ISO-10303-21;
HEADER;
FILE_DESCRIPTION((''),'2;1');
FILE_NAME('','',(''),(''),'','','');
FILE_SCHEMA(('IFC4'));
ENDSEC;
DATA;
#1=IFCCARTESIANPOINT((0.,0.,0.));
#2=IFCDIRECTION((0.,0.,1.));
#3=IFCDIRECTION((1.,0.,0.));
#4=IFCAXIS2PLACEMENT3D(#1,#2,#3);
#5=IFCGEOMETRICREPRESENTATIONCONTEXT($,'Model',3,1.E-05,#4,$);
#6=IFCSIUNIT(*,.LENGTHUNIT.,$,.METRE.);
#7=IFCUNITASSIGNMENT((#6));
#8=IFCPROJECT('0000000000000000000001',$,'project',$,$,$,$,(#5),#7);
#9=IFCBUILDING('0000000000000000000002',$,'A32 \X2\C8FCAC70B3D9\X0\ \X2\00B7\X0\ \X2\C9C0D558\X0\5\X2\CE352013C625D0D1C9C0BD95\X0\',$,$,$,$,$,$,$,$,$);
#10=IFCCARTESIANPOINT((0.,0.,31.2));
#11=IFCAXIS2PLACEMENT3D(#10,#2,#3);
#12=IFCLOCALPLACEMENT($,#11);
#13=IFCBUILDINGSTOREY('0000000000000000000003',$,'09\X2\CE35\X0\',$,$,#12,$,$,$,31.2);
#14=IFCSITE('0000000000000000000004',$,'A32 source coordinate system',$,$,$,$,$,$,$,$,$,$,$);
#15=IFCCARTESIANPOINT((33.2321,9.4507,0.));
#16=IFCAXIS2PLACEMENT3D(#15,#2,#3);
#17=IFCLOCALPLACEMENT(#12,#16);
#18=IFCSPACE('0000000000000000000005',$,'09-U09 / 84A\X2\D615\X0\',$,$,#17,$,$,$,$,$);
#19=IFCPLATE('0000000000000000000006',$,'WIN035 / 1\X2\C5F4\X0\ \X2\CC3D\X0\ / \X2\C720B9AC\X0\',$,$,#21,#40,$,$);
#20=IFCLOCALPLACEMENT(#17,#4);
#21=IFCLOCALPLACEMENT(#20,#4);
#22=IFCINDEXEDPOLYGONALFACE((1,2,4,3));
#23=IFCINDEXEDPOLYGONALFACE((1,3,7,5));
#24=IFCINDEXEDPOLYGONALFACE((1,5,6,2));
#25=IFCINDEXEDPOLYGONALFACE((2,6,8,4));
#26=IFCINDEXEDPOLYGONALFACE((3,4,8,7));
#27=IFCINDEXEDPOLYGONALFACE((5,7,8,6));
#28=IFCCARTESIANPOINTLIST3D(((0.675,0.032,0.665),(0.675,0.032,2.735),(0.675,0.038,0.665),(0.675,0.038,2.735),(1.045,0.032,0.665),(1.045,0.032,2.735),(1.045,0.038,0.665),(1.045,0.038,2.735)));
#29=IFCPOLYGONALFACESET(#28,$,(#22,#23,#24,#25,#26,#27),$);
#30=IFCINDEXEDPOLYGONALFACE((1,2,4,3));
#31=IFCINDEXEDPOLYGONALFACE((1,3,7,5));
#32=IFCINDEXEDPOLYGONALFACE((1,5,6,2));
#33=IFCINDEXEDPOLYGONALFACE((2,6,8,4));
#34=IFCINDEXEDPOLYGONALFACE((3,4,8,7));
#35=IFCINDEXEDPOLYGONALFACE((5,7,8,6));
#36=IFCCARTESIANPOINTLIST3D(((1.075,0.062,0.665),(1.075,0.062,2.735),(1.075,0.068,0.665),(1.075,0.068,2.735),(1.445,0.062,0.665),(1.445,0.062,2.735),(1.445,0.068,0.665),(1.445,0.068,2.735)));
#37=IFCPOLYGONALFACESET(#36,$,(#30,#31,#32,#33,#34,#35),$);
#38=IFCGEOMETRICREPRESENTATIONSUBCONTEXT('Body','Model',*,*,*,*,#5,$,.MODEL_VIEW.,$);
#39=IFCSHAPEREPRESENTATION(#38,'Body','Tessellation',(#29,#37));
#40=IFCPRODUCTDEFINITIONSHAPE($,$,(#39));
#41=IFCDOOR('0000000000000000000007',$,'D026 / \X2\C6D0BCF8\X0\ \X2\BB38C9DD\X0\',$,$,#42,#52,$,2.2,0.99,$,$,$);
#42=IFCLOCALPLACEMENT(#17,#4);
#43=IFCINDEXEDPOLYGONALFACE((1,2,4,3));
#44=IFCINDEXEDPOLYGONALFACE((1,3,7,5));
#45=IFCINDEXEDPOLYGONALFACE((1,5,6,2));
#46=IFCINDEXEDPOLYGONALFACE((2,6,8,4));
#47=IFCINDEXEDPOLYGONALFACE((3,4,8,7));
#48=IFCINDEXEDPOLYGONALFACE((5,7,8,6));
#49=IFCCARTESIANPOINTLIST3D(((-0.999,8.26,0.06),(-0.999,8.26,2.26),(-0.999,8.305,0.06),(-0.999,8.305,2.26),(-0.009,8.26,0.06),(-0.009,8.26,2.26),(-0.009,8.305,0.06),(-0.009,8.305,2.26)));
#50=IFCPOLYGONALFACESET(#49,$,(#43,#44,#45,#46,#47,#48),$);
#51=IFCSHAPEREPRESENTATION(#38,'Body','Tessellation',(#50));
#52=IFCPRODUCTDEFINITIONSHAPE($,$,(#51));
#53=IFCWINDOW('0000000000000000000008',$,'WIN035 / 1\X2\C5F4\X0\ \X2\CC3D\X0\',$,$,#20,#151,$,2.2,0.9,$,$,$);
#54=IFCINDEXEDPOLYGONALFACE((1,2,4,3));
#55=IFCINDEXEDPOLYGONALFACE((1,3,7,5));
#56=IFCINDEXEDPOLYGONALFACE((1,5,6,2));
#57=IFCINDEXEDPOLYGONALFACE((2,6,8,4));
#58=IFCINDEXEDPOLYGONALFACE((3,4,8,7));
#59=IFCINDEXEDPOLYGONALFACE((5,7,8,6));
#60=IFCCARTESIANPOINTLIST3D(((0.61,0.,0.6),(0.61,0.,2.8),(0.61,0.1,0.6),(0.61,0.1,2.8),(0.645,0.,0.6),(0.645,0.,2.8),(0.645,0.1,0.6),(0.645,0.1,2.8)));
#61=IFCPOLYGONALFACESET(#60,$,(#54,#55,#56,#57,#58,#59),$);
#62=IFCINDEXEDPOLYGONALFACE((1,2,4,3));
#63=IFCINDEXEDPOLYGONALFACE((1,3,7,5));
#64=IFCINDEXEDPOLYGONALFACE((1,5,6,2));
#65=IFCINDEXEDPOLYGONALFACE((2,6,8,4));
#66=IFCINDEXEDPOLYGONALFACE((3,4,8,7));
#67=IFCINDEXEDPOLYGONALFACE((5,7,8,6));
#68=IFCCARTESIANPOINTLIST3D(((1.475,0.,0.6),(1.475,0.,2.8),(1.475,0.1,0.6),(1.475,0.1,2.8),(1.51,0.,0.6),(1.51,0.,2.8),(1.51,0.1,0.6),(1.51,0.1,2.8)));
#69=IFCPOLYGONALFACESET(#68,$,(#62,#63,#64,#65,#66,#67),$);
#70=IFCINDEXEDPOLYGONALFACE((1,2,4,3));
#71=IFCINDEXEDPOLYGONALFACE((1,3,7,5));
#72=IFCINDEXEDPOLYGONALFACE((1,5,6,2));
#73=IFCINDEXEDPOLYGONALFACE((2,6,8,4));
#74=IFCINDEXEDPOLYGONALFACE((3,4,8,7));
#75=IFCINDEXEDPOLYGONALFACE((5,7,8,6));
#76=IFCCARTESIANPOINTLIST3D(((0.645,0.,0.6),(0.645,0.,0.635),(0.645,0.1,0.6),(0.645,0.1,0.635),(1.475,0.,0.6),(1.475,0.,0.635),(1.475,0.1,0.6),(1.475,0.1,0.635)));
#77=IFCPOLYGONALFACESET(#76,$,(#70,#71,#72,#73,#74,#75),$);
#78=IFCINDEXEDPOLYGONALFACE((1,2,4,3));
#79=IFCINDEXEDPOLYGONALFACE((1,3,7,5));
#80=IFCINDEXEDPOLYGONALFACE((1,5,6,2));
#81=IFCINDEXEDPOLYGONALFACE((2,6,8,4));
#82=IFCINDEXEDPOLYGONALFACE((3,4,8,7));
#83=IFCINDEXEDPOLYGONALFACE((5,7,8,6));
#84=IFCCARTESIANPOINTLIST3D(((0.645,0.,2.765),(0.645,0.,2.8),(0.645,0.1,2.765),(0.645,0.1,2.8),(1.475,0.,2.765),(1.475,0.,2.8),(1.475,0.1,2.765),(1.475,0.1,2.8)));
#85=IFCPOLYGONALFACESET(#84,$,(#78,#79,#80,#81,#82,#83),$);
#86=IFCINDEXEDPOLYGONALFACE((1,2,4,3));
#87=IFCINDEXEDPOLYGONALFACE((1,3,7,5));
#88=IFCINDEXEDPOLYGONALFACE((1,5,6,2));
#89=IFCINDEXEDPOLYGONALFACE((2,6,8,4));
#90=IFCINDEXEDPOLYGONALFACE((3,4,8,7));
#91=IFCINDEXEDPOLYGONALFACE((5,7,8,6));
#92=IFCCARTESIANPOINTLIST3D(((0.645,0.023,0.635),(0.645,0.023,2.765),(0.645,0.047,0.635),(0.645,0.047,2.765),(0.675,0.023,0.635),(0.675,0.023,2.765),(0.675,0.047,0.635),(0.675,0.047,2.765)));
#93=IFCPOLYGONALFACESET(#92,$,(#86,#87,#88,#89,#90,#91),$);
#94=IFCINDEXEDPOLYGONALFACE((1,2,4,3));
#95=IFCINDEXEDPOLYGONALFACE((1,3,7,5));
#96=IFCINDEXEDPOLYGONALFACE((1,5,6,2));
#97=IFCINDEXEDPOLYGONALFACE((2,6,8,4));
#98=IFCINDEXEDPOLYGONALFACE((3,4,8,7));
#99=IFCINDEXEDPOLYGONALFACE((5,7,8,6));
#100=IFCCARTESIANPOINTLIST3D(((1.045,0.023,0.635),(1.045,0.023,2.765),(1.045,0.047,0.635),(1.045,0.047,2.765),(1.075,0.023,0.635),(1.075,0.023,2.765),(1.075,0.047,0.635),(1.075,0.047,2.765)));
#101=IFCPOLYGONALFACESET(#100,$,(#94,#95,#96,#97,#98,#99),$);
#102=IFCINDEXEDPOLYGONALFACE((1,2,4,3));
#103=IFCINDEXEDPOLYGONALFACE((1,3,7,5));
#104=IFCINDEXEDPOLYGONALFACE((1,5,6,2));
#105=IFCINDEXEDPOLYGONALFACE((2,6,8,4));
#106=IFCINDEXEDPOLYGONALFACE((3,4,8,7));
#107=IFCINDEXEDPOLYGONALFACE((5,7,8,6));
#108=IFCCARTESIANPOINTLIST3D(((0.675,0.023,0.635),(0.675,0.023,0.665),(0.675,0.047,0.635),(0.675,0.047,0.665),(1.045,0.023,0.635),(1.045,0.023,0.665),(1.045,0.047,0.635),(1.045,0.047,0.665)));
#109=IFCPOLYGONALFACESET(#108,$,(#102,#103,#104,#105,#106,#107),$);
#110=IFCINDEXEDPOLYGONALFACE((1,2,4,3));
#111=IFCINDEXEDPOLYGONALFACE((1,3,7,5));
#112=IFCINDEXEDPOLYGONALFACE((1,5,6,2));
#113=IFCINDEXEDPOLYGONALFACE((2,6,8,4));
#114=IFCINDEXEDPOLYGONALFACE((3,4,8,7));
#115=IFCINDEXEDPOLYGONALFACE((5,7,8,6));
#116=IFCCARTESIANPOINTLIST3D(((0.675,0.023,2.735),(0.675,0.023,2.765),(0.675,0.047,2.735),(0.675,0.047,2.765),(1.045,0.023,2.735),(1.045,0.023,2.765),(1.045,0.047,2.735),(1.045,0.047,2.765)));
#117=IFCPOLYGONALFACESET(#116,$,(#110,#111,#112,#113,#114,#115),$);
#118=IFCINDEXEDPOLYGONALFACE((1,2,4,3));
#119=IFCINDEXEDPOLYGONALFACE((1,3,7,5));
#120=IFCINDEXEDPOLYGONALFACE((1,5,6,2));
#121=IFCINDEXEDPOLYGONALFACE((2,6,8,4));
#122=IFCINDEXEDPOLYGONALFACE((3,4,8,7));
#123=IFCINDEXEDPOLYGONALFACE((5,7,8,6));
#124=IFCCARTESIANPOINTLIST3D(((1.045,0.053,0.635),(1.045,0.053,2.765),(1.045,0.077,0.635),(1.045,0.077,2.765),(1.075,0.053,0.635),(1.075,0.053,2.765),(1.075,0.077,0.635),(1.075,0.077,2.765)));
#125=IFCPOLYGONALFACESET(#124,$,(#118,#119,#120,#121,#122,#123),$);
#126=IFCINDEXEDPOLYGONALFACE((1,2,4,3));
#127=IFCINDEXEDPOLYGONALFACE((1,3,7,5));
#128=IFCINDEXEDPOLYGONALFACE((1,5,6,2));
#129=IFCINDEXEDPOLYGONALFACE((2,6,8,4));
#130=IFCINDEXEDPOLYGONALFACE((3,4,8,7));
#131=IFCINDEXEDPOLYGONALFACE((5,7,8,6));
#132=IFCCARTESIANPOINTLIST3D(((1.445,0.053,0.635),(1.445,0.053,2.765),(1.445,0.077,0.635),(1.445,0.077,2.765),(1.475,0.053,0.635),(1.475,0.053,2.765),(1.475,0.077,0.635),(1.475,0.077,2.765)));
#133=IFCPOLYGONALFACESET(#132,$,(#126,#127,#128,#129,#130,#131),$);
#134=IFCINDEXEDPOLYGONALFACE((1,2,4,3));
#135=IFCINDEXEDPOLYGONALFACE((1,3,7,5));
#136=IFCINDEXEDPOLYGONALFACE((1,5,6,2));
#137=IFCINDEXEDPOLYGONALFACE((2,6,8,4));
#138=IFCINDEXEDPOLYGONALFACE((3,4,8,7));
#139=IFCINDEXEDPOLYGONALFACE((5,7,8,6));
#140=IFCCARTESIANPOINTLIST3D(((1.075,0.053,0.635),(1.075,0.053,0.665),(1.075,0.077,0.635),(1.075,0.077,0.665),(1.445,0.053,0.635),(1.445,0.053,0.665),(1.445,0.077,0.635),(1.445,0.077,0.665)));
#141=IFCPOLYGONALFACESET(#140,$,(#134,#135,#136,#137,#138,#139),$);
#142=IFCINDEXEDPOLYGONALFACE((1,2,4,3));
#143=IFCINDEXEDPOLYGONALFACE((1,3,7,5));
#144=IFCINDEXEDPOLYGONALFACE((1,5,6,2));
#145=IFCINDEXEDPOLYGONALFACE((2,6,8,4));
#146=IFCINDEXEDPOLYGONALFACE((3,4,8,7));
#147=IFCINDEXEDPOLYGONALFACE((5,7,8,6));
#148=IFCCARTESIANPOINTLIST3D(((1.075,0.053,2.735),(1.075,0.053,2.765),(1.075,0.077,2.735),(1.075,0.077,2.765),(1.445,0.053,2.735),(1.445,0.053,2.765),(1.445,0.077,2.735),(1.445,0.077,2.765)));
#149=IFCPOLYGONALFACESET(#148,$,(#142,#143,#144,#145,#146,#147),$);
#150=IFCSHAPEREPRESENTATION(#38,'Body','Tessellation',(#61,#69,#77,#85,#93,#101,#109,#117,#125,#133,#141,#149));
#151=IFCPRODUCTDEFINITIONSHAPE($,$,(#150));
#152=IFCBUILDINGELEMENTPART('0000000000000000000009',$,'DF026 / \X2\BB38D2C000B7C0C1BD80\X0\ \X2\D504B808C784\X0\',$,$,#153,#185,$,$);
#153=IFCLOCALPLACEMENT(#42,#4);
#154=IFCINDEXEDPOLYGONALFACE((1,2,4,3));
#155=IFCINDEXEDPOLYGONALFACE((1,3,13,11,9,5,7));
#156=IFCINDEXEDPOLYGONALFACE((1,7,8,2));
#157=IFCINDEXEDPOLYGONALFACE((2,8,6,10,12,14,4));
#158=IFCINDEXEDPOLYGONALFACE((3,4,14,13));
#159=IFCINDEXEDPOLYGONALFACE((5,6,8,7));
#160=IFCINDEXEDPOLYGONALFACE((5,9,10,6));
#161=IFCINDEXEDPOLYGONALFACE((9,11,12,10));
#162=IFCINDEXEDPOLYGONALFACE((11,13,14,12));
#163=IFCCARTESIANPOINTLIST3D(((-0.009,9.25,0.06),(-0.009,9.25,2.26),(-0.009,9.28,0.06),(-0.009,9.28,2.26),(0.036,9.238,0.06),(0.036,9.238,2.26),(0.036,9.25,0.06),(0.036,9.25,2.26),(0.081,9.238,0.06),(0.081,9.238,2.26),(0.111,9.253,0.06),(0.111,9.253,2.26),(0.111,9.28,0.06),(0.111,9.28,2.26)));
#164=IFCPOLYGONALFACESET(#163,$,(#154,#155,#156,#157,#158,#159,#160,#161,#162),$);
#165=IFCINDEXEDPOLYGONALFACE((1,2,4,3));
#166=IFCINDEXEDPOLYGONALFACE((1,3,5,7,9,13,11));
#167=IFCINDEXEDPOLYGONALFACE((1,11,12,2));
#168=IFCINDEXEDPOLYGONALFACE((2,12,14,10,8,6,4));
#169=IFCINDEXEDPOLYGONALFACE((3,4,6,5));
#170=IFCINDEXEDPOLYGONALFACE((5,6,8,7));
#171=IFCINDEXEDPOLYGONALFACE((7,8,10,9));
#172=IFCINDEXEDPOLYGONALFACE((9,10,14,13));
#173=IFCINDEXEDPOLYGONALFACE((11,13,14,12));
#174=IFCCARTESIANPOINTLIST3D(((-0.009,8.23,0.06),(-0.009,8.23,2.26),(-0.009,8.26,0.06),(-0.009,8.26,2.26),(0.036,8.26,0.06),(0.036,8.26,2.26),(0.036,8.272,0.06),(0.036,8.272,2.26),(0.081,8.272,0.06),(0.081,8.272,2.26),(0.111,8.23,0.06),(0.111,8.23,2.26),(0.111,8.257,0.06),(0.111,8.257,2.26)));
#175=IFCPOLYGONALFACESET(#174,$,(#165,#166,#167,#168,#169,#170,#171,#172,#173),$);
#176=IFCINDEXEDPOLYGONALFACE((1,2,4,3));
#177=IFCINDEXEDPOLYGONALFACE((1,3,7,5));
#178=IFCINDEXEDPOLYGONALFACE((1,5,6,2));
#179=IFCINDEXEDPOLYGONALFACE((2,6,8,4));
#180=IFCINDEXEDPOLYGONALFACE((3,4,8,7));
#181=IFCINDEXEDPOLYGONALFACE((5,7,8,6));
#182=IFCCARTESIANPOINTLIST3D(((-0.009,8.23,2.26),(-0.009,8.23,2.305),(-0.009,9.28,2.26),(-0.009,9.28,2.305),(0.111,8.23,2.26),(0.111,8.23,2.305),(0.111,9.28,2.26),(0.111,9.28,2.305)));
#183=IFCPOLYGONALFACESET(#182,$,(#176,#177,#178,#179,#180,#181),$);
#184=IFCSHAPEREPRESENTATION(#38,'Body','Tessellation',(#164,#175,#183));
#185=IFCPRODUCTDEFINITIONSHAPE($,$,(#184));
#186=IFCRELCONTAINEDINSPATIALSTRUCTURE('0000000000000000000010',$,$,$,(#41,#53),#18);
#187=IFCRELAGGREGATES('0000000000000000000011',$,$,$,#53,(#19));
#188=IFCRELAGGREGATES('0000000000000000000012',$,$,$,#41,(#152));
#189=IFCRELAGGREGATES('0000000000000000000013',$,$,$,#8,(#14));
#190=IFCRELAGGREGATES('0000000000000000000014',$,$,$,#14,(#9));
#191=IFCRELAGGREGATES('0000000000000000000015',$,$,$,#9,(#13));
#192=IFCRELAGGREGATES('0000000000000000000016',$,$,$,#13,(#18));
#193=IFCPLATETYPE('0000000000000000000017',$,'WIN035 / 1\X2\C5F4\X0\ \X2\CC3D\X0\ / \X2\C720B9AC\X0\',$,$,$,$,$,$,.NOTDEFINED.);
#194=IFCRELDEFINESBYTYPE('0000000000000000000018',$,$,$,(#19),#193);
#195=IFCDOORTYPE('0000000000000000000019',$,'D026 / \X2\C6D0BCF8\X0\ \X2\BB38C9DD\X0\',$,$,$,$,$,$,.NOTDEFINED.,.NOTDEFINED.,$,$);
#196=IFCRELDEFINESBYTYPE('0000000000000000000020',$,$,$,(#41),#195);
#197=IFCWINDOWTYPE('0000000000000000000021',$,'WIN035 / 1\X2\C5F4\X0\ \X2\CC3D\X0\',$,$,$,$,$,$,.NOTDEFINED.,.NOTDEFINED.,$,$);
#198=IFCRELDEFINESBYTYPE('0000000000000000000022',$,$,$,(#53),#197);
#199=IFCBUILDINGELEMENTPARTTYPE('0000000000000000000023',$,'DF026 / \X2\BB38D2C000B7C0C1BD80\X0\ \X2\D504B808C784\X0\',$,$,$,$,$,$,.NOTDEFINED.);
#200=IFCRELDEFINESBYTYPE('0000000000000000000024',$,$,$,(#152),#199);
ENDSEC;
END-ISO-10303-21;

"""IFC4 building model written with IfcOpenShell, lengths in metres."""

from ifc_helpers import new_model, si_unit, frame, origin, origin_with_axes, place, context, subcontext, project, spatial, polyline, outline, extrude, source, transform, mapped, type_object, type_shapes, element, aggregate, save


model = new_model("IFC4")

# Units and contexts
model_context = context("Model", 3, precision=1e-05, world=origin_with_axes())
body_context = subcontext(model_context, "Body", "Model", "MODEL_VIEW")
ifc_project = project(units=[si_unit("LENGTHUNIT", "METRE")], contexts=[model_context])

# Plate
plate_type_1 = type_object("IfcPlateType", Name="WIN035 / 1열 창 / 유리", PredefinedType="NOTDEFINED")
shared_shape_1 = source(origin(), body_context, "Body", "SweptSolid", [
    extrude(outline(polyline([(0.675, 0.032), (0.675, 0.038), (1.045, 0.038), (1.045, 0.032), (0.675, 0.032)])), frame((0.0, 0.0, 0.665)), (0.0, 0.0, 1.0), 2.07),
    extrude(outline(polyline([(1.075, 0.062), (1.075, 0.068), (1.445, 0.068), (1.445, 0.062), (1.075, 0.062)])), frame((0.0, 0.0, 0.665)), (0.0, 0.0, 1.0), 2.07),
])
type_shapes(plate_type_1, [shared_shape_1])
storey_placement = place(None, frame((0.0, 0.0, 31.2), z_axis=(0.0, 0.0, 1.0), x_axis=(1.0, 0.0, 0.0)))
space_placement = place(storey_placement, frame((33.2321, 9.4507, 0.0), z_axis=(0.0, 0.0, 1.0), x_axis=(1.0, 0.0, 0.0)))
window_1_placement = place(space_placement, origin_with_axes())
plate_1_placement = place(window_1_placement, origin_with_axes())
plate_1 = element("IfcPlate", 1, at=plate_1_placement, type_object=plate_type_1, Name="WIN035 / 1열 창 / 유리", context=body_context, shape_type="MappedRepresentation", body=[
    mapped(shared_shape_1, transform((0.0, 0.0, 0.0), scale=1.0)),
])

# Site, building, storey, space
site = spatial("IfcSite", under=ifc_project, Name="A32 source coordinate system")
building = spatial("IfcBuilding", under=site, Name="A32 주거동 · 지하5층–옥탑지붕")
storey = spatial("IfcBuildingStorey", under=building, at=storey_placement, Name="09층", Elevation=31.2)
space = spatial("IfcSpace", under=storey, at=space_placement, Name="09-U09 / 84A형")

# Door
door_type_1 = type_object("IfcDoorType", Name="D026 / 원본 문짝", OperationType="NOTDEFINED", PredefinedType="NOTDEFINED")
shared_shape_2 = source(origin(), body_context, "Body", "SweptSolid", [
    extrude(outline(polyline([(-0.009, 8.26), (-0.999, 8.26), (-0.999, 8.305), (-0.009, 8.305), (-0.009, 8.26)])), frame((0.0, 0.0, 0.06)), (0.0, 0.0, 1.0), 2.2),
])
type_shapes(door_type_1, [shared_shape_2])
door_1_placement = place(space_placement, origin_with_axes())
door_1 = element("IfcDoor", 2, at=door_1_placement, inside=space, type_object=door_type_1, Name="D026 / 원본 문짝", OverallHeight=2.2, OverallWidth=0.99, context=body_context, shape_type="MappedRepresentation", body=[
    mapped(shared_shape_2, transform((0.0, 0.0, 0.0), scale=1.0)),
])

# Window
window_type_1 = type_object("IfcWindowType", Name="WIN035 / 1열 창", PartitioningType="NOTDEFINED", PredefinedType="NOTDEFINED")
shared_shape_3 = source(origin(), body_context, "Body", "SweptSolid", [
    extrude(outline(polyline([(0.61, 0.0), (0.61, 0.1), (0.645, 0.1), (0.645, 0.0), (0.61, 0.0)])), frame((0.0, 0.0, 0.6)), (0.0, 0.0, 1.0), 2.2),
    extrude(outline(polyline([(1.475, 0.0), (1.475, 0.1), (1.51, 0.1), (1.51, 0.0), (1.475, 0.0)])), frame((0.0, 0.0, 0.6)), (0.0, 0.0, 1.0), 2.2),
    extrude(outline(polyline([(0.645, 0.0), (0.645, 0.1), (1.475, 0.1), (1.475, 0.0), (0.645, 0.0)])), frame((0.0, 0.0, 0.6)), (0.0, 0.0, 1.0), 0.035),
    extrude(outline(polyline([(0.645, 0.0), (0.645, 0.1), (1.475, 0.1), (1.475, 0.0), (0.645, 0.0)])), frame((0.0, 0.0, 2.765)), (0.0, 0.0, 1.0), 0.035),
    extrude(outline(polyline([(0.645, 0.023), (0.645, 0.047), (0.675, 0.047), (0.675, 0.023), (0.645, 0.023)])), frame((0.0, 0.0, 0.635)), (0.0, 0.0, 1.0), 2.13),
    extrude(outline(polyline([(1.045, 0.023), (1.045, 0.047), (1.075, 0.047), (1.075, 0.023), (1.045, 0.023)])), frame((0.0, 0.0, 0.635)), (0.0, 0.0, 1.0), 2.13),
    extrude(outline(polyline([(0.675, 0.023), (0.675, 0.047), (1.045, 0.047), (1.045, 0.023), (0.675, 0.023)])), frame((0.0, 0.0, 0.635)), (0.0, 0.0, 1.0), 0.03),
    extrude(outline(polyline([(0.675, 0.023), (0.675, 0.047), (1.045, 0.047), (1.045, 0.023), (0.675, 0.023)])), frame((0.0, 0.0, 2.735)), (0.0, 0.0, 1.0), 0.03),
    extrude(outline(polyline([(1.045, 0.053), (1.045, 0.077), (1.075, 0.077), (1.075, 0.053), (1.045, 0.053)])), frame((0.0, 0.0, 0.635)), (0.0, 0.0, 1.0), 2.13),
    extrude(outline(polyline([(1.445, 0.053), (1.445, 0.077), (1.475, 0.077), (1.475, 0.053), (1.445, 0.053)])), frame((0.0, 0.0, 0.635)), (0.0, 0.0, 1.0), 2.13),
    extrude(outline(polyline([(1.075, 0.053), (1.075, 0.077), (1.445, 0.077), (1.445, 0.053), (1.075, 0.053)])), frame((0.0, 0.0, 0.635)), (0.0, 0.0, 1.0), 0.03),
    extrude(outline(polyline([(1.075, 0.053), (1.075, 0.077), (1.445, 0.077), (1.445, 0.053), (1.075, 0.053)])), frame((0.0, 0.0, 2.735)), (0.0, 0.0, 1.0), 0.03),
])
type_shapes(window_type_1, [shared_shape_3])
window_1 = element("IfcWindow", 3, at=window_1_placement, inside=space, type_object=window_type_1, Name="WIN035 / 1열 창", OverallHeight=2.2, OverallWidth=0.9, context=body_context, shape_type="MappedRepresentation", body=[
    mapped(shared_shape_3, transform((0.0, 0.0, 0.0), scale=1.0)),
])
aggregate(window_1, [plate_1])

# Building element part
building_element_part_type_1 = type_object("IfcBuildingElementPartType", Name="DF026 / 문틀·상부 프레임", PredefinedType="NOTDEFINED")
shared_shape_4 = source(origin(), body_context, "Body", "SweptSolid", [
    extrude(outline(polyline([(0.111, 9.28), (0.111, 9.253), (0.081, 9.238), (0.036, 9.238), (0.036, 9.25), (-0.009, 9.25), (-0.009, 9.28), (0.111, 9.28)])), frame((0.0, 0.0, 0.06)), (0.0, 0.0, 1.0), 2.2),
    extrude(outline(polyline([(-0.009, 8.26), (0.036, 8.26), (0.036, 8.272), (0.081, 8.272), (0.111, 8.257), (0.111, 8.23), (-0.009, 8.23), (-0.009, 8.26)])), frame((0.0, 0.0, 0.06)), (0.0, 0.0, 1.0), 2.2),
    extrude(outline(polyline([(-0.009, 8.23), (-0.009, 9.28), (0.111, 9.28), (0.111, 8.23), (-0.009, 8.23)])), frame((0.0, 0.0, 2.26)), (0.0, 0.0, 1.0), 0.045),
])
type_shapes(building_element_part_type_1, [shared_shape_4])
building_element_part_1_placement = place(door_1_placement, origin_with_axes())
building_element_part_1 = element("IfcBuildingElementPart", 4, at=building_element_part_1_placement, type_object=building_element_part_type_1, Name="DF026 / 문틀·상부 프레임", context=body_context, shape_type="MappedRepresentation", body=[
    mapped(shared_shape_4, transform((0.0, 0.0, 0.0), scale=1.0)),
])
aggregate(door_1, [building_element_part_1])

save(model, "model.ifc")
